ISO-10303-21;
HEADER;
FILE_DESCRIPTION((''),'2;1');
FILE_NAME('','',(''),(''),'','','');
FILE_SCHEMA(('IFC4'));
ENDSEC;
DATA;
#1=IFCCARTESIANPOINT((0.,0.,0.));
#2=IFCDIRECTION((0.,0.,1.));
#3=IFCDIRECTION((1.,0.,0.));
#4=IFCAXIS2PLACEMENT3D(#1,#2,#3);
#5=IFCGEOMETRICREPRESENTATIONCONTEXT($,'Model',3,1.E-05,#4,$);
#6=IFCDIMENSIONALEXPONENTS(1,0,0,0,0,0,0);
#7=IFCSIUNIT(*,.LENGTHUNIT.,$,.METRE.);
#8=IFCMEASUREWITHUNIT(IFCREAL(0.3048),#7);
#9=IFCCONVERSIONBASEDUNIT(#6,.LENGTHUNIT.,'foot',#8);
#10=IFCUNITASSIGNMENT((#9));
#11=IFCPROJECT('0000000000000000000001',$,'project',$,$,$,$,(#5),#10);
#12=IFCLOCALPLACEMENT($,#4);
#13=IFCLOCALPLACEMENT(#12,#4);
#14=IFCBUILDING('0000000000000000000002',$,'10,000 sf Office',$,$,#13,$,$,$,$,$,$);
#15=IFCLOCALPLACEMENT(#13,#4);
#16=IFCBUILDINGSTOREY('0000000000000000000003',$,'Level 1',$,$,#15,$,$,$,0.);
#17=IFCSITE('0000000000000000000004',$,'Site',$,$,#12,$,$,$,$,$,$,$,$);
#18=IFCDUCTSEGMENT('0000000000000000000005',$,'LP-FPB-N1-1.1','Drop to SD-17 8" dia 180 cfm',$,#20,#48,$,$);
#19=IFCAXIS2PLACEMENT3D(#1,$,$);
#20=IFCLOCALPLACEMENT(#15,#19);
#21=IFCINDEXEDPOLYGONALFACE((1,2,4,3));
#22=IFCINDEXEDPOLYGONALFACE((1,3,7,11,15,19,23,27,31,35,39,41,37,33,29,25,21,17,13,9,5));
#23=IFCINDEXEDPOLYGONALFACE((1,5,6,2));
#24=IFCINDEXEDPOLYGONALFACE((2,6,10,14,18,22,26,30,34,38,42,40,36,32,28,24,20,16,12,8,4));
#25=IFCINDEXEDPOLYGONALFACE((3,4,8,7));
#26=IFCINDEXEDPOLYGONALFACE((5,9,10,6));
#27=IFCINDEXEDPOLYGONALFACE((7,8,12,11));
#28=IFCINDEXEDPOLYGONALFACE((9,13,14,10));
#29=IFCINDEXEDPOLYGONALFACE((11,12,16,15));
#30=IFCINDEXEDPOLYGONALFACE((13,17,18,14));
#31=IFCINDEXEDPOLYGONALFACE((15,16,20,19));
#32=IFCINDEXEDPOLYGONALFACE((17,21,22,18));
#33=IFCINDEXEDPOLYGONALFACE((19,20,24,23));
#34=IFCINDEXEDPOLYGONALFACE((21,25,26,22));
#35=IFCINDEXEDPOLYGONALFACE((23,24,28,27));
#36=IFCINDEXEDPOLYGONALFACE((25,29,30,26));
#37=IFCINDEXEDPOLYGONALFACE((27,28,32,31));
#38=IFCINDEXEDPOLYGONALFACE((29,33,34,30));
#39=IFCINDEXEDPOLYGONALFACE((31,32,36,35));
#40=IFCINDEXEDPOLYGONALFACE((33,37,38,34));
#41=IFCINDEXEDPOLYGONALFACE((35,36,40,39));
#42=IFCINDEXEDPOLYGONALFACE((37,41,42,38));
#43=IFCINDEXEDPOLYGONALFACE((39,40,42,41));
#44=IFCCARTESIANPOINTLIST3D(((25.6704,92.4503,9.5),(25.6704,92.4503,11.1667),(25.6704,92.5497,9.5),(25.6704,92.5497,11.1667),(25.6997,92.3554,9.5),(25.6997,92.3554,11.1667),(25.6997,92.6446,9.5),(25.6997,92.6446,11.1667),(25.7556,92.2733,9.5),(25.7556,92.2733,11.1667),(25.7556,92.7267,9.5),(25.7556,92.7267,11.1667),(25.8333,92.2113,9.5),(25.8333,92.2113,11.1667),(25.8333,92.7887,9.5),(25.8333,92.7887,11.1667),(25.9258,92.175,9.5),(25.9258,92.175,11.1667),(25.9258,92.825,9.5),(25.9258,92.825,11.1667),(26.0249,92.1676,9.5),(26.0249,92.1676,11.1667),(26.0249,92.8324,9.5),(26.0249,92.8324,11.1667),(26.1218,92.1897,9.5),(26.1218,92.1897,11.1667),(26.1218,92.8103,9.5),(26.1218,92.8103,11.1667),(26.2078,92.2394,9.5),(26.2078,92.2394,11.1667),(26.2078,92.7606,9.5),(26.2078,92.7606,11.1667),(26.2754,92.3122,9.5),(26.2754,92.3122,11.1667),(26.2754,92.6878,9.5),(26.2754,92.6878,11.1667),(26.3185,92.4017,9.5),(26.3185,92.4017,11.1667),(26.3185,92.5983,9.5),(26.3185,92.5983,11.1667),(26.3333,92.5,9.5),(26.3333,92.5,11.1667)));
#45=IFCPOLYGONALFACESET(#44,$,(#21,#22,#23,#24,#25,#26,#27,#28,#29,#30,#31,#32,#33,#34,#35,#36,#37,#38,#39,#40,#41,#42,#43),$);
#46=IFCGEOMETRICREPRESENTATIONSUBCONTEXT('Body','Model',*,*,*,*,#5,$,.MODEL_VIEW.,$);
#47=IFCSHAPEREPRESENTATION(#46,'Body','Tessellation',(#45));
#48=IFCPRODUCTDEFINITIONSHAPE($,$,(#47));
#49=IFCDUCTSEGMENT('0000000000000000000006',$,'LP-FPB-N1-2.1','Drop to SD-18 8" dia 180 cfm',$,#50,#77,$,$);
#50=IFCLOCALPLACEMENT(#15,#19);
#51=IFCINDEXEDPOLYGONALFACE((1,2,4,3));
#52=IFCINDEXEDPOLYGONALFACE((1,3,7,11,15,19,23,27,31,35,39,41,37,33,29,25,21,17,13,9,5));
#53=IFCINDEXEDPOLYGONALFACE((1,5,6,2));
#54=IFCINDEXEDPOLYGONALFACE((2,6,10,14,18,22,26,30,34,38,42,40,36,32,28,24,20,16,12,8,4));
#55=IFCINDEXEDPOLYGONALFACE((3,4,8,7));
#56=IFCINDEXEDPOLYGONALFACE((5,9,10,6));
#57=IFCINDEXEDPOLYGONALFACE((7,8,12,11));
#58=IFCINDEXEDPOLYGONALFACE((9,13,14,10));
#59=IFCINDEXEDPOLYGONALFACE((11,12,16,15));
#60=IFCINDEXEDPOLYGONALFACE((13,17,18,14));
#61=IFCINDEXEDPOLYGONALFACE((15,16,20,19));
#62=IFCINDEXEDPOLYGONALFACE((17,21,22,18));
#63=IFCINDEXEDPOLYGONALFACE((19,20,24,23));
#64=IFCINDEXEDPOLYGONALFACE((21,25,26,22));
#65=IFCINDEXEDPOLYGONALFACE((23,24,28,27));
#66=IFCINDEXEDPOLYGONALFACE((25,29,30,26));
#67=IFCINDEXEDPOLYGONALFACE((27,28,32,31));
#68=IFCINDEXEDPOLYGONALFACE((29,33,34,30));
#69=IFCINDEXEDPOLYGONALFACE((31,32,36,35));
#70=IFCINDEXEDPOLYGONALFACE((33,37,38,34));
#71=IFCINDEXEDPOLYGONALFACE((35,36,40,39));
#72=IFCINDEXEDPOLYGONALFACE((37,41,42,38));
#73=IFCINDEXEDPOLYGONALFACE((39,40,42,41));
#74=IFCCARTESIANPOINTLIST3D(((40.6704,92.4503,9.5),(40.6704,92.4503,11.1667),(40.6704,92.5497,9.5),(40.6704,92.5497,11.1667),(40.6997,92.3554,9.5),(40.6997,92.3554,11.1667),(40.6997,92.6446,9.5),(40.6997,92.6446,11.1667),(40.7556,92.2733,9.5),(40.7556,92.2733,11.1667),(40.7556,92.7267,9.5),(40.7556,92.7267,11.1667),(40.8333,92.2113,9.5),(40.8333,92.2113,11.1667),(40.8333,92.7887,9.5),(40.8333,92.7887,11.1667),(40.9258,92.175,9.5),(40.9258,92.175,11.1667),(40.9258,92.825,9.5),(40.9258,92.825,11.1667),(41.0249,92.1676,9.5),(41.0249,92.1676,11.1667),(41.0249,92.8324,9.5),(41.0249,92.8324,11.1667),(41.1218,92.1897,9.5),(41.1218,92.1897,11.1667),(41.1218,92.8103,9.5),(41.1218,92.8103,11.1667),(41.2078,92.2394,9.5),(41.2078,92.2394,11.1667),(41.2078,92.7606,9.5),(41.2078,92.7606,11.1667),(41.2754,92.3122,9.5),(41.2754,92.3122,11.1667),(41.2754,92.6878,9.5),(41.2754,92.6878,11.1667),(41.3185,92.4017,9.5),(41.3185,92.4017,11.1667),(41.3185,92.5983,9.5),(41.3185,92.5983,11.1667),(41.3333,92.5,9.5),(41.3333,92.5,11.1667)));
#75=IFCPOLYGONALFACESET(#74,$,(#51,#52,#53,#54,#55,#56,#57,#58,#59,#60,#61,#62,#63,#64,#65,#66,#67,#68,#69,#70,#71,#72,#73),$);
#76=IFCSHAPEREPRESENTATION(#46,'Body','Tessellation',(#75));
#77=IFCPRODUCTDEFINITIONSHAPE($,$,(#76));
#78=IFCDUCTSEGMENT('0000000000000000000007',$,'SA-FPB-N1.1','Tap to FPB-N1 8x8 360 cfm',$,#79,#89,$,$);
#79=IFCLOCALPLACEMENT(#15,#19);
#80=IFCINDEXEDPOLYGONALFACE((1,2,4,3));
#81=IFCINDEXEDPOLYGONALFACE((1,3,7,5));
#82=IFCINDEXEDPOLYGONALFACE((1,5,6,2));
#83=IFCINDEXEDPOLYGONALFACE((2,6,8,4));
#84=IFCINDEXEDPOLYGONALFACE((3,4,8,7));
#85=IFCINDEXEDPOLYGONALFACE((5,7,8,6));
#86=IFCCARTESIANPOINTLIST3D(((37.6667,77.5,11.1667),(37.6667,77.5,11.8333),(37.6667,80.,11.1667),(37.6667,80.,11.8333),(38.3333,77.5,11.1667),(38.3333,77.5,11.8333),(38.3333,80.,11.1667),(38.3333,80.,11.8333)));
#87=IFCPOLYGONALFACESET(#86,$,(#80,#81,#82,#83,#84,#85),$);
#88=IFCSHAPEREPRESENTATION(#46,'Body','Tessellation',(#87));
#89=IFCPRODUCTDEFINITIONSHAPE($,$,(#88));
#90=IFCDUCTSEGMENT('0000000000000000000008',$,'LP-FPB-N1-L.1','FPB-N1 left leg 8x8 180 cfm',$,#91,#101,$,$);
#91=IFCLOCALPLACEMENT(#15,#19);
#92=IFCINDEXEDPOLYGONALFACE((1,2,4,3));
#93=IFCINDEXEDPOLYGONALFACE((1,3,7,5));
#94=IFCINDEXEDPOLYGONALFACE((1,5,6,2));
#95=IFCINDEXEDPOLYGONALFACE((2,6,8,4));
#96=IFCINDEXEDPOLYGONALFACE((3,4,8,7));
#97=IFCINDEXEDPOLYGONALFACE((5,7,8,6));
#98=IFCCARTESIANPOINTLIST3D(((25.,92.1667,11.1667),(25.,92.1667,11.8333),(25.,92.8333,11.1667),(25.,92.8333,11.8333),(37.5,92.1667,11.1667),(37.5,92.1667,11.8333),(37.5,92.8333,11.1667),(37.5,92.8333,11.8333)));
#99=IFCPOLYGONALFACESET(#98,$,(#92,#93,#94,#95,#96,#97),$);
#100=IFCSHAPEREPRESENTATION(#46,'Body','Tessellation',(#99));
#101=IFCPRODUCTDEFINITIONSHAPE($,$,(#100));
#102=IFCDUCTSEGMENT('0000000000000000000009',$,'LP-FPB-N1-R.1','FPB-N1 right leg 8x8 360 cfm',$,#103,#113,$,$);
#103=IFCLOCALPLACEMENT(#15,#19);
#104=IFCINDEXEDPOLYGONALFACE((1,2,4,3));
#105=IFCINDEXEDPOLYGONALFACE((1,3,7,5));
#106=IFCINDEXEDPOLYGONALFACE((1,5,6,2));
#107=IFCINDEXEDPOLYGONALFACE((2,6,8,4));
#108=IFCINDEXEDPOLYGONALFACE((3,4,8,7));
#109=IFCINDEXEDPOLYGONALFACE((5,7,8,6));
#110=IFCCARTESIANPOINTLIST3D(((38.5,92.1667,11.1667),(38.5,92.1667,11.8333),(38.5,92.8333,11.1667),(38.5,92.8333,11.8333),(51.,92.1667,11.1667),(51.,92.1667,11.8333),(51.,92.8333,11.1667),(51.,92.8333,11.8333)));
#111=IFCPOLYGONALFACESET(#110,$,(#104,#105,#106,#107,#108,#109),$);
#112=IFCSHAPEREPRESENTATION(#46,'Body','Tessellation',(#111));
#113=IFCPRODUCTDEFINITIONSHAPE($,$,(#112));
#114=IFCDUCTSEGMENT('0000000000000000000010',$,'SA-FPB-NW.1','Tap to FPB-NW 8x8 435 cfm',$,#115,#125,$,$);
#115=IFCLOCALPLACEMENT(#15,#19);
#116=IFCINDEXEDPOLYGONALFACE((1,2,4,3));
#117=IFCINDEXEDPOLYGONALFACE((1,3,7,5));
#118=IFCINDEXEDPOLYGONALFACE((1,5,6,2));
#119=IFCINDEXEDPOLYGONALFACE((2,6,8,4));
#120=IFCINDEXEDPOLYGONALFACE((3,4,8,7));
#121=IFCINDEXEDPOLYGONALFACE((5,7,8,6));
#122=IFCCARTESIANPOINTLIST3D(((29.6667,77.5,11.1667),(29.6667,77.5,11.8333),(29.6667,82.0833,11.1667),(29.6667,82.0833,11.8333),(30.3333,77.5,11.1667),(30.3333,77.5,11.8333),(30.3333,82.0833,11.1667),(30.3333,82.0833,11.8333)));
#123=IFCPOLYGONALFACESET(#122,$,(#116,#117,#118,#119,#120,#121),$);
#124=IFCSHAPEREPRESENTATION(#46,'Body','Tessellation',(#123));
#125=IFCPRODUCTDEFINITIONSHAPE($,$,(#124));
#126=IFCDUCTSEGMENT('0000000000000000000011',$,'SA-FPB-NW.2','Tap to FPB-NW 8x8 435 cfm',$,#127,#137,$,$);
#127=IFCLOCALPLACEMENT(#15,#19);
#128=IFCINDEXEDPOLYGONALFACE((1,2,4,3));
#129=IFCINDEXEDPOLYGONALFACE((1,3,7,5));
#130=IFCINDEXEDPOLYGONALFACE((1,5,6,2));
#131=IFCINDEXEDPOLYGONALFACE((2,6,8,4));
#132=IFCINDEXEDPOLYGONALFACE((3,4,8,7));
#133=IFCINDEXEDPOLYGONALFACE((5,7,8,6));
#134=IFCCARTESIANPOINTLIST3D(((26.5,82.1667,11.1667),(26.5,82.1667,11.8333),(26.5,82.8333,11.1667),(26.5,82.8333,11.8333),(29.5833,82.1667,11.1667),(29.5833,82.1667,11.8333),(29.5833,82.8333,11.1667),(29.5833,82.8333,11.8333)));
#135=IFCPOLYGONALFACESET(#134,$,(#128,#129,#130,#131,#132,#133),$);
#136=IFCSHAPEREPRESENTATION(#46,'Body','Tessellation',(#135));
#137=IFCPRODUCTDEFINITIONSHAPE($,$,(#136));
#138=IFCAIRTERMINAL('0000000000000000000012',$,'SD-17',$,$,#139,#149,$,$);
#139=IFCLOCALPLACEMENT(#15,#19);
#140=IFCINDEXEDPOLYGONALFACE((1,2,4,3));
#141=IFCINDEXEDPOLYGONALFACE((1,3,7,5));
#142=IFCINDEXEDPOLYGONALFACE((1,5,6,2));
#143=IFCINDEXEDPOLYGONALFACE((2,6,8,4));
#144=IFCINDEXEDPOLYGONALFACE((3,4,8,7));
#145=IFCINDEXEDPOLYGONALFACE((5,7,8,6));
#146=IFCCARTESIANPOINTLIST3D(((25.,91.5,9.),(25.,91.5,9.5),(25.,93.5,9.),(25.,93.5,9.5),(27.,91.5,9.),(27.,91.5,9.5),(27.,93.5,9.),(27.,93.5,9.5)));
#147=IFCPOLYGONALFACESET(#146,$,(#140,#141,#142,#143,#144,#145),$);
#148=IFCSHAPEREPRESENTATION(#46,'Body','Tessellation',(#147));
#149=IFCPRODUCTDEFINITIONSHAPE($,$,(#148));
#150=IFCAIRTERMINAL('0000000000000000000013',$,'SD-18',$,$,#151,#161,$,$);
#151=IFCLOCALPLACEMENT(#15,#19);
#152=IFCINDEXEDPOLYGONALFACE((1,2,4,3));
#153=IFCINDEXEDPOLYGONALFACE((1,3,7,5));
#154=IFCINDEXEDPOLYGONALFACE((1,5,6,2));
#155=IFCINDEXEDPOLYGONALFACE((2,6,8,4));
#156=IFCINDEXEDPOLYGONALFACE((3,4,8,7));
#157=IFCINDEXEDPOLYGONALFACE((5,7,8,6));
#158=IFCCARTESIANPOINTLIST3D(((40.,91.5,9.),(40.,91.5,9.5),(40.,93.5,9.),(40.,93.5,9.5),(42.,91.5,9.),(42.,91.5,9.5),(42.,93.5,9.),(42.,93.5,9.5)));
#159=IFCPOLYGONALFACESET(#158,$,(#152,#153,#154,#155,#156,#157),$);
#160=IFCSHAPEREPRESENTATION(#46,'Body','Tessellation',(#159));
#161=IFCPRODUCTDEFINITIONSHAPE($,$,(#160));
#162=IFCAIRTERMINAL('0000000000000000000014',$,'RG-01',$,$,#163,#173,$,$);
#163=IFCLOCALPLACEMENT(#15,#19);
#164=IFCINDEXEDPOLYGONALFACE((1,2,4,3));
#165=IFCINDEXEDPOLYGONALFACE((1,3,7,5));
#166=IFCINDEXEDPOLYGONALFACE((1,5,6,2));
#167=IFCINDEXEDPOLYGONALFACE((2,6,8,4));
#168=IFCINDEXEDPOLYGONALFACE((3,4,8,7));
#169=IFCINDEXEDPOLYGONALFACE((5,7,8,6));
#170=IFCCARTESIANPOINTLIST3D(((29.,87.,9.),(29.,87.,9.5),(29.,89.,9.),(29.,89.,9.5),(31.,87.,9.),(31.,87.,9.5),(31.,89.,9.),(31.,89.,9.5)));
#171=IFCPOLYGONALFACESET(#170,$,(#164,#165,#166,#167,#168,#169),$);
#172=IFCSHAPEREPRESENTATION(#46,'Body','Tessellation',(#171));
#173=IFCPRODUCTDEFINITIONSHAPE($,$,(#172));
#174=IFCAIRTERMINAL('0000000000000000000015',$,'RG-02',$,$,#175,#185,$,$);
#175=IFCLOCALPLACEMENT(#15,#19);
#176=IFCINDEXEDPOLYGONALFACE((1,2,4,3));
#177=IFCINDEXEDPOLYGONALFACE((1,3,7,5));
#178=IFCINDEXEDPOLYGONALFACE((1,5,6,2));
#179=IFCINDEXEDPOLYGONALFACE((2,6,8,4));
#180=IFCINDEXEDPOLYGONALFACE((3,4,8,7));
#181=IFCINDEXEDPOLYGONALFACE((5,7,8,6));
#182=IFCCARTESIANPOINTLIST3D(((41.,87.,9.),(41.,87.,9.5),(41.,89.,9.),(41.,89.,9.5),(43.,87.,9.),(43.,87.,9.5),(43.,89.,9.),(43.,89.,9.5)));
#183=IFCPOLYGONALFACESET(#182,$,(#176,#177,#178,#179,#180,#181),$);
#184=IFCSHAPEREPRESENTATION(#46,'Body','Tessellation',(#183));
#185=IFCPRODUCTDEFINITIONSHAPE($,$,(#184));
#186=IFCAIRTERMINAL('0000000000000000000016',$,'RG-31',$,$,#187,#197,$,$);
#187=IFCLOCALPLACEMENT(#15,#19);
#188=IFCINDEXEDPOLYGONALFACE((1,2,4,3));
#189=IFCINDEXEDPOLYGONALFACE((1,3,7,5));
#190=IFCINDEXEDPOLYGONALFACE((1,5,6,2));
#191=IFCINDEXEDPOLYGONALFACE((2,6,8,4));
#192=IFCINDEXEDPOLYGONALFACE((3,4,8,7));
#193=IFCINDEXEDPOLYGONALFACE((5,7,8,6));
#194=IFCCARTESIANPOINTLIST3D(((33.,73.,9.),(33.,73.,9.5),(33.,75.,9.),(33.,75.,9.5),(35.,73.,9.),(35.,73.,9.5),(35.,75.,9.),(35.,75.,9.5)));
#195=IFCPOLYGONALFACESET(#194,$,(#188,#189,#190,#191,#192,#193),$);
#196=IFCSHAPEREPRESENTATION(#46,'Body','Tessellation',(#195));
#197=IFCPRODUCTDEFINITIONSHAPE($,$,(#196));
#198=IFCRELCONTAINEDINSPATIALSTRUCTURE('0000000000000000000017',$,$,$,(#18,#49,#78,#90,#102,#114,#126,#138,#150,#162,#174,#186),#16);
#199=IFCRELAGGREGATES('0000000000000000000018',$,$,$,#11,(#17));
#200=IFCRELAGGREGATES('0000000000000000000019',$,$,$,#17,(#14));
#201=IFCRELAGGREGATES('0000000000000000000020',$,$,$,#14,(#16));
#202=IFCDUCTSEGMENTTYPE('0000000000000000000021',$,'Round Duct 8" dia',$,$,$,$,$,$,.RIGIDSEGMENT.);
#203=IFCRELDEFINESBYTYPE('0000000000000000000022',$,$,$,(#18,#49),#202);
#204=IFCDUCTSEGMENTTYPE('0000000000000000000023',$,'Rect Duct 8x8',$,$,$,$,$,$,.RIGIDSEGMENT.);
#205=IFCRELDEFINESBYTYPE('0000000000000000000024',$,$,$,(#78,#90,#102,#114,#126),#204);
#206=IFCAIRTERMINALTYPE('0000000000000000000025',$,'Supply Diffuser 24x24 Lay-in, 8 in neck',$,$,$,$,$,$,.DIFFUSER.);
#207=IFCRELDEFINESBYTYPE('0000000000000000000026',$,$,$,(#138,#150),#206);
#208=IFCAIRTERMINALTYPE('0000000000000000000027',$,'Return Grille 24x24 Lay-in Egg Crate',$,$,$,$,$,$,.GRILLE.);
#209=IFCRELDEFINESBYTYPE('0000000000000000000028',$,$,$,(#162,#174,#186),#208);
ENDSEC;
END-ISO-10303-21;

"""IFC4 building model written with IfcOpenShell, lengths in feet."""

from ifc_helpers import new_model, entity, si_unit, converted_unit, frame, origin_with_axes, place, context, subcontext, project, spatial, rectangle, circle, extrude, type_object, element, save


model = new_model("IFC4")

# Units and contexts
model_context = context("Model", 3, precision=1e-05, world=origin_with_axes())
body_context = subcontext(model_context, "Body", "Model", "MODEL_VIEW")
ifc_project = project(units=[converted_unit("LENGTHUNIT", "foot", entity("IfcReal", 0.3048), si_unit("LENGTHUNIT", "METRE"), dimensions=[1, 0, 0, 0, 0, 0, 0])], contexts=[model_context])

# Site, building, storey
site_placement = place(None, origin_with_axes())
site = spatial("IfcSite", under=ifc_project, at=site_placement, Name="Site")
building_placement = place(site_placement, origin_with_axes())
building = spatial("IfcBuilding", under=site, at=building_placement, Name="10,000 sf Office")
storey_placement = place(building_placement, origin_with_axes())
storey = spatial("IfcBuildingStorey", under=building, at=storey_placement, Name="Level 1", Elevation=0.0)

# Duct segments
duct_segment_type_1 = type_object("IfcDuctSegmentType", Name="Round Duct 8\" dia", PredefinedType="RIGIDSEGMENT")
for number, where, z_axis, x_axis, name, description in (
    (1, (26.0, 92.5, 11.1667), (0.0, 0.0, -1.0), (1.0, 0.0, 0.0), "LP-FPB-N1-1.1", "Drop to SD-17 8\" dia 180 cfm"),
    (2, (41.0, 92.5, 11.1667), (0.0, 0.0, -1.0), (1.0, 0.0, 0.0), "LP-FPB-N1-2.1", "Drop to SD-18 8\" dia 180 cfm"),
):
    element("IfcDuctSegment", number, at=place(storey_placement, frame(where, z_axis=z_axis, x_axis=x_axis)), inside=storey, type_object=duct_segment_type_1, Name=name, Description=description, context=body_context, shape_type="SweptSolid", body=[
        extrude(circle(Radius=0.3333), None, (0.0, 0.0, 1.0), 1.6667),
    ])
duct_segment_type_2 = type_object("IfcDuctSegmentType", Name="Rect Duct 8x8", PredefinedType="RIGIDSEGMENT")
duct_segment_1_placement = place(storey_placement, frame((38.0, 77.5, 11.5), z_axis=(0.0, 1.0, 0.0), x_axis=(-1.0, 0.0, 0.0)))
element("IfcDuctSegment", 3, at=duct_segment_1_placement, inside=storey, type_object=duct_segment_type_2, Name="SA-FPB-N1.1", Description="Tap to FPB-N1 8x8 360 cfm", context=body_context, shape_type="SweptSolid", body=[
    extrude(rectangle(XDim=0.6667, YDim=0.6667), None, (0.0, 0.0, 1.0), 2.5),
])
for number, where, z_axis, x_axis, name, description in (
    (4, (37.5, 92.5, 11.5), (-1.0, 0.0, 0.0), (0.0, -1.0, 0.0), "LP-FPB-N1-L.1", "FPB-N1 left leg 8x8 180 cfm"),
    (5, (38.5, 92.5, 11.5), (1.0, 0.0, 0.0), (0.0, 1.0, 0.0), "LP-FPB-N1-R.1", "FPB-N1 right leg 8x8 360 cfm"),
):
    element("IfcDuctSegment", number, at=place(storey_placement, frame(where, z_axis=z_axis, x_axis=x_axis)), inside=storey, type_object=duct_segment_type_2, Name=name, Description=description, context=body_context, shape_type="SweptSolid", body=[
        extrude(rectangle(XDim=0.6667, YDim=0.6667), None, (0.0, 0.0, 1.0), 12.5),
    ])
duct_segment_2_placement = place(storey_placement, frame((30.0, 77.5, 11.5), z_axis=(0.0, 1.0, 0.0), x_axis=(-1.0, 0.0, 0.0)))
element("IfcDuctSegment", 6, at=duct_segment_2_placement, inside=storey, type_object=duct_segment_type_2, Name="SA-FPB-NW.1", Description="Tap to FPB-NW 8x8 435 cfm", context=body_context, shape_type="SweptSolid", body=[
    extrude(rectangle(XDim=0.6667, YDim=0.6667), None, (0.0, 0.0, 1.0), 4.5833),
])
duct_segment_3_placement = place(storey_placement, frame((29.5833, 82.5, 11.5), z_axis=(-1.0, 0.0, 0.0), x_axis=(0.0, -1.0, 0.0)))
element("IfcDuctSegment", 7, at=duct_segment_3_placement, inside=storey, type_object=duct_segment_type_2, Name="SA-FPB-NW.2", Description="Tap to FPB-NW 8x8 435 cfm", context=body_context, shape_type="SweptSolid", body=[
    extrude(rectangle(XDim=0.6667, YDim=0.6667), None, (0.0, 0.0, 1.0), 3.0833),
])

# Air terminals
air_terminal_type_1 = type_object("IfcAirTerminalType", Name="Supply Diffuser 24x24 Lay-in, 8 in neck", PredefinedType="DIFFUSER")
for number, where, z_axis, x_axis, name in (
    (8, (26.0, 92.5, 9.0), (0.0, 0.0, 1.0), (1.0, 0.0, 0.0), "SD-17"),
    (9, (41.0, 92.5, 9.0), (0.0, 0.0, 1.0), (1.0, 0.0, 0.0), "SD-18"),
):
    element("IfcAirTerminal", number, at=place(storey_placement, frame(where, z_axis=z_axis, x_axis=x_axis)), inside=storey, type_object=air_terminal_type_1, Name=name, context=body_context, shape_type="SweptSolid", body=[
        extrude(rectangle(XDim=2.0, YDim=2.0), None, (0.0, 0.0, 1.0), 0.5),
    ])
air_terminal_type_2 = type_object("IfcAirTerminalType", Name="Return Grille 24x24 Lay-in Egg Crate", PredefinedType="GRILLE")
for number, where, z_axis, x_axis, name in (
    (10, (30.0, 88.0, 9.0), (0.0, 0.0, 1.0), (1.0, 0.0, 0.0), "RG-01"),
    (11, (42.0, 88.0, 9.0), (0.0, 0.0, 1.0), (1.0, 0.0, 0.0), "RG-02"),
    (12, (34.0, 74.0, 9.0), (0.0, 0.0, 1.0), (1.0, 0.0, 0.0), "RG-31"),
):
    element("IfcAirTerminal", number, at=place(storey_placement, frame(where, z_axis=z_axis, x_axis=x_axis)), inside=storey, type_object=air_terminal_type_2, Name=name, context=body_context, shape_type="SweptSolid", body=[
        extrude(rectangle(XDim=2.0, YDim=2.0), None, (0.0, 0.0, 1.0), 0.5),
    ])

save(model, "model.ifc")
